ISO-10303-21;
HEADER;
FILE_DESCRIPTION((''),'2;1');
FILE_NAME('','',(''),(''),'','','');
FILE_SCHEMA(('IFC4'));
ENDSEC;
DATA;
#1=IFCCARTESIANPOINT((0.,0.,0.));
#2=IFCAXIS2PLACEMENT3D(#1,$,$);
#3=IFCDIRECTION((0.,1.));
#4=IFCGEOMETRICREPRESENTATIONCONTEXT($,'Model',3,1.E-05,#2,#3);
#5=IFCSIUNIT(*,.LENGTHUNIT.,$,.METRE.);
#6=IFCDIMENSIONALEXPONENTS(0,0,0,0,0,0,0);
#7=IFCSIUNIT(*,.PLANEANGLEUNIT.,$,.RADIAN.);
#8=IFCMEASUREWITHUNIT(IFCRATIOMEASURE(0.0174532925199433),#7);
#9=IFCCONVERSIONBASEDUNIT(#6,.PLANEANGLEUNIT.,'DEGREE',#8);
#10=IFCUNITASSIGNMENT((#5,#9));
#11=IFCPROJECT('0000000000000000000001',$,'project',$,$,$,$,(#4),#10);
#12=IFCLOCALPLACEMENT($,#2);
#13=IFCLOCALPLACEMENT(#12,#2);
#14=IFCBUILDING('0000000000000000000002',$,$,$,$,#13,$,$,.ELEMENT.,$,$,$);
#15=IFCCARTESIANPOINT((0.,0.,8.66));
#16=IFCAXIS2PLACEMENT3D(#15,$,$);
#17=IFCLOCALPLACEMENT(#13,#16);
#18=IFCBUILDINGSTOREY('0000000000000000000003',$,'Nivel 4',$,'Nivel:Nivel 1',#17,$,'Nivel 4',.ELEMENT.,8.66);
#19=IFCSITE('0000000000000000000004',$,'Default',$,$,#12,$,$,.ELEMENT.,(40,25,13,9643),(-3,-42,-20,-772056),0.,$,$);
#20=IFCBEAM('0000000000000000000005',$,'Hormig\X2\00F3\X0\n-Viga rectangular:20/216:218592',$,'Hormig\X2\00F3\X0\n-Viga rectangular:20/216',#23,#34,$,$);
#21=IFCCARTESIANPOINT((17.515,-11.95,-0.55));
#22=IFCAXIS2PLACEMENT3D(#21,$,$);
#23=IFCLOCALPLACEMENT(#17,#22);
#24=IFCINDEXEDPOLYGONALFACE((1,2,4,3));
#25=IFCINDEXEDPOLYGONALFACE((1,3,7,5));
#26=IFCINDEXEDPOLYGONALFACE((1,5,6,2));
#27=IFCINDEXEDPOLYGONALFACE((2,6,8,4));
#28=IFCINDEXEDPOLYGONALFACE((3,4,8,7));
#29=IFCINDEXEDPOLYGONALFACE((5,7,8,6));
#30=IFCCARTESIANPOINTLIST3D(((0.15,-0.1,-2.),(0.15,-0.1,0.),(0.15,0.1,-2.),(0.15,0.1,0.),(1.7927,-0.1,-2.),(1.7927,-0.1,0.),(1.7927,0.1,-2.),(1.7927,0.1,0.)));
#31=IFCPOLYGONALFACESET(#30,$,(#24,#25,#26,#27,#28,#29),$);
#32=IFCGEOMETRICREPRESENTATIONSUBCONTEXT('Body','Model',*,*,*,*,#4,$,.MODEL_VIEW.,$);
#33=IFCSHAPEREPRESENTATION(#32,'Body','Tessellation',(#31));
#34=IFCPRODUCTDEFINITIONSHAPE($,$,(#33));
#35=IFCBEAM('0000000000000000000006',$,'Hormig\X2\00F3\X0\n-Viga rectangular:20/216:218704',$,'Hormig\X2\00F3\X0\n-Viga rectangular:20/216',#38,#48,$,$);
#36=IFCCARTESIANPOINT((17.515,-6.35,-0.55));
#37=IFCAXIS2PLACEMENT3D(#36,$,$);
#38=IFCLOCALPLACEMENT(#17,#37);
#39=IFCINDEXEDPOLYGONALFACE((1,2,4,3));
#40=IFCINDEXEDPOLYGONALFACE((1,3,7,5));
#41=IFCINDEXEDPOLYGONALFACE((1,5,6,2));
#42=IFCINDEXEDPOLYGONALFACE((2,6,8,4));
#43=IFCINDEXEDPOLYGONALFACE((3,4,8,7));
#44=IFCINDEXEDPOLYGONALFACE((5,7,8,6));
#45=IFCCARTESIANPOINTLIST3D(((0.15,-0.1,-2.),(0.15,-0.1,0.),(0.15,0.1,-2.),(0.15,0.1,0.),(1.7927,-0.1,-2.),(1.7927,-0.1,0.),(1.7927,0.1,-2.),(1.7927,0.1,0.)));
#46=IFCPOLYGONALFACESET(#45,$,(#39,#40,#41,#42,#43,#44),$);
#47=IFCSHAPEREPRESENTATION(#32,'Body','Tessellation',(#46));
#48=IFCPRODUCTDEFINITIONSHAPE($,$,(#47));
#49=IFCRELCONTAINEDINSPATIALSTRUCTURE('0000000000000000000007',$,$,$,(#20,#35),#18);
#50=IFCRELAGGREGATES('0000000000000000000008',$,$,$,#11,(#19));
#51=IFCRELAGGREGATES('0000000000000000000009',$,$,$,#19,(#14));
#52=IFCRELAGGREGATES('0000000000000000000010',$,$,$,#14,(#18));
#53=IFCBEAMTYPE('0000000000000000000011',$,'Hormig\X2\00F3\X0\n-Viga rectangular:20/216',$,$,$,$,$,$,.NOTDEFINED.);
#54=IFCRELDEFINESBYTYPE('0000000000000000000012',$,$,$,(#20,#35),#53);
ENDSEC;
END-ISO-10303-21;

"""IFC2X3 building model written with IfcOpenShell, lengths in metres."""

from ifc_helpers import new_model, entity, si_unit, converted_unit, direction, frame, frame_2d, origin, place, context, subcontext, project, spatial, rectangle, extrude, type_object, element, save


model = new_model("IFC2X3")

# Units and contexts
model_context = context("Model", 3, precision=1e-05, world=origin(), true_north=direction((0.0, 1.0)))
body_context = subcontext(model_context, "Body", "Model", "MODEL_VIEW")
ifc_project = project(units=[si_unit("LENGTHUNIT", "METRE"), converted_unit("PLANEANGLEUNIT", "DEGREE", entity("IfcRatioMeasure", 0.0174532925199433), si_unit("PLANEANGLEUNIT", "RADIAN"), dimensions=[0, 0, 0, 0, 0, 0, 0])], contexts=[model_context])

# Site, building, storey
site_placement = place(None, origin())
site = spatial("IfcSite", under=ifc_project, at=site_placement, Name="Default", CompositionType="ELEMENT", RefLatitude=(40, 25, 13, 9643), RefLongitude=(-3, -42, -20, -772056), RefElevation=0.0)
building_placement = place(site_placement, origin())
building = spatial("IfcBuilding", under=site, at=building_placement, CompositionType="ELEMENT")
storey_placement = place(building_placement, frame((0.0, 0.0, 8.66)))
storey = spatial("IfcBuildingStorey", under=building, at=storey_placement, Name="Nivel 4", ObjectType="Nivel:Nivel 1", LongName="Nivel 4", CompositionType="ELEMENT", Elevation=8.66)

# Beams
beam_type_1 = type_object("IfcBeamType", Name="Hormigón-Viga rectangular:20/216", PredefinedType="NOTDEFINED")
beam_1_placement = place(storey_placement, frame((17.515, -11.95, -0.55)))
element("IfcBeam", 1, at=beam_1_placement, inside=storey, type_object=beam_type_1, Name="Hormigón-Viga rectangular:20/216:218592", ObjectType="Hormigón-Viga rectangular:20/216", context=body_context, shape_type="SweptSolid", body=[
    extrude(rectangle(XDim=2.0, YDim=0.2, at=frame_2d((0.0, 0.0), x_axis=(1.0, 0.0))), frame((0.15, 0.0, -1.0), z_axis=(1.0, 0.0, 0.0), x_axis=(0.0, 0.0, -1.0)), (0.0, 0.0, 1.0), 1.6427),
])
beam_2_placement = place(storey_placement, frame((17.515, -6.35, -0.55)))
element("IfcBeam", 2, at=beam_2_placement, inside=storey, type_object=beam_type_1, Name="Hormigón-Viga rectangular:20/216:218704", ObjectType="Hormigón-Viga rectangular:20/216", context=body_context, shape_type="SweptSolid", body=[
    extrude(rectangle(XDim=2.0, YDim=0.2, at=frame_2d((0.0, 0.0), x_axis=(1.0, 0.0))), frame((0.15, 0.0, -1.0), z_axis=(1.0, 0.0, 0.0), x_axis=(0.0, 0.0, -1.0)), (0.0, 0.0, 1.0), 1.6427),
])

save(model, "model.ifc")
